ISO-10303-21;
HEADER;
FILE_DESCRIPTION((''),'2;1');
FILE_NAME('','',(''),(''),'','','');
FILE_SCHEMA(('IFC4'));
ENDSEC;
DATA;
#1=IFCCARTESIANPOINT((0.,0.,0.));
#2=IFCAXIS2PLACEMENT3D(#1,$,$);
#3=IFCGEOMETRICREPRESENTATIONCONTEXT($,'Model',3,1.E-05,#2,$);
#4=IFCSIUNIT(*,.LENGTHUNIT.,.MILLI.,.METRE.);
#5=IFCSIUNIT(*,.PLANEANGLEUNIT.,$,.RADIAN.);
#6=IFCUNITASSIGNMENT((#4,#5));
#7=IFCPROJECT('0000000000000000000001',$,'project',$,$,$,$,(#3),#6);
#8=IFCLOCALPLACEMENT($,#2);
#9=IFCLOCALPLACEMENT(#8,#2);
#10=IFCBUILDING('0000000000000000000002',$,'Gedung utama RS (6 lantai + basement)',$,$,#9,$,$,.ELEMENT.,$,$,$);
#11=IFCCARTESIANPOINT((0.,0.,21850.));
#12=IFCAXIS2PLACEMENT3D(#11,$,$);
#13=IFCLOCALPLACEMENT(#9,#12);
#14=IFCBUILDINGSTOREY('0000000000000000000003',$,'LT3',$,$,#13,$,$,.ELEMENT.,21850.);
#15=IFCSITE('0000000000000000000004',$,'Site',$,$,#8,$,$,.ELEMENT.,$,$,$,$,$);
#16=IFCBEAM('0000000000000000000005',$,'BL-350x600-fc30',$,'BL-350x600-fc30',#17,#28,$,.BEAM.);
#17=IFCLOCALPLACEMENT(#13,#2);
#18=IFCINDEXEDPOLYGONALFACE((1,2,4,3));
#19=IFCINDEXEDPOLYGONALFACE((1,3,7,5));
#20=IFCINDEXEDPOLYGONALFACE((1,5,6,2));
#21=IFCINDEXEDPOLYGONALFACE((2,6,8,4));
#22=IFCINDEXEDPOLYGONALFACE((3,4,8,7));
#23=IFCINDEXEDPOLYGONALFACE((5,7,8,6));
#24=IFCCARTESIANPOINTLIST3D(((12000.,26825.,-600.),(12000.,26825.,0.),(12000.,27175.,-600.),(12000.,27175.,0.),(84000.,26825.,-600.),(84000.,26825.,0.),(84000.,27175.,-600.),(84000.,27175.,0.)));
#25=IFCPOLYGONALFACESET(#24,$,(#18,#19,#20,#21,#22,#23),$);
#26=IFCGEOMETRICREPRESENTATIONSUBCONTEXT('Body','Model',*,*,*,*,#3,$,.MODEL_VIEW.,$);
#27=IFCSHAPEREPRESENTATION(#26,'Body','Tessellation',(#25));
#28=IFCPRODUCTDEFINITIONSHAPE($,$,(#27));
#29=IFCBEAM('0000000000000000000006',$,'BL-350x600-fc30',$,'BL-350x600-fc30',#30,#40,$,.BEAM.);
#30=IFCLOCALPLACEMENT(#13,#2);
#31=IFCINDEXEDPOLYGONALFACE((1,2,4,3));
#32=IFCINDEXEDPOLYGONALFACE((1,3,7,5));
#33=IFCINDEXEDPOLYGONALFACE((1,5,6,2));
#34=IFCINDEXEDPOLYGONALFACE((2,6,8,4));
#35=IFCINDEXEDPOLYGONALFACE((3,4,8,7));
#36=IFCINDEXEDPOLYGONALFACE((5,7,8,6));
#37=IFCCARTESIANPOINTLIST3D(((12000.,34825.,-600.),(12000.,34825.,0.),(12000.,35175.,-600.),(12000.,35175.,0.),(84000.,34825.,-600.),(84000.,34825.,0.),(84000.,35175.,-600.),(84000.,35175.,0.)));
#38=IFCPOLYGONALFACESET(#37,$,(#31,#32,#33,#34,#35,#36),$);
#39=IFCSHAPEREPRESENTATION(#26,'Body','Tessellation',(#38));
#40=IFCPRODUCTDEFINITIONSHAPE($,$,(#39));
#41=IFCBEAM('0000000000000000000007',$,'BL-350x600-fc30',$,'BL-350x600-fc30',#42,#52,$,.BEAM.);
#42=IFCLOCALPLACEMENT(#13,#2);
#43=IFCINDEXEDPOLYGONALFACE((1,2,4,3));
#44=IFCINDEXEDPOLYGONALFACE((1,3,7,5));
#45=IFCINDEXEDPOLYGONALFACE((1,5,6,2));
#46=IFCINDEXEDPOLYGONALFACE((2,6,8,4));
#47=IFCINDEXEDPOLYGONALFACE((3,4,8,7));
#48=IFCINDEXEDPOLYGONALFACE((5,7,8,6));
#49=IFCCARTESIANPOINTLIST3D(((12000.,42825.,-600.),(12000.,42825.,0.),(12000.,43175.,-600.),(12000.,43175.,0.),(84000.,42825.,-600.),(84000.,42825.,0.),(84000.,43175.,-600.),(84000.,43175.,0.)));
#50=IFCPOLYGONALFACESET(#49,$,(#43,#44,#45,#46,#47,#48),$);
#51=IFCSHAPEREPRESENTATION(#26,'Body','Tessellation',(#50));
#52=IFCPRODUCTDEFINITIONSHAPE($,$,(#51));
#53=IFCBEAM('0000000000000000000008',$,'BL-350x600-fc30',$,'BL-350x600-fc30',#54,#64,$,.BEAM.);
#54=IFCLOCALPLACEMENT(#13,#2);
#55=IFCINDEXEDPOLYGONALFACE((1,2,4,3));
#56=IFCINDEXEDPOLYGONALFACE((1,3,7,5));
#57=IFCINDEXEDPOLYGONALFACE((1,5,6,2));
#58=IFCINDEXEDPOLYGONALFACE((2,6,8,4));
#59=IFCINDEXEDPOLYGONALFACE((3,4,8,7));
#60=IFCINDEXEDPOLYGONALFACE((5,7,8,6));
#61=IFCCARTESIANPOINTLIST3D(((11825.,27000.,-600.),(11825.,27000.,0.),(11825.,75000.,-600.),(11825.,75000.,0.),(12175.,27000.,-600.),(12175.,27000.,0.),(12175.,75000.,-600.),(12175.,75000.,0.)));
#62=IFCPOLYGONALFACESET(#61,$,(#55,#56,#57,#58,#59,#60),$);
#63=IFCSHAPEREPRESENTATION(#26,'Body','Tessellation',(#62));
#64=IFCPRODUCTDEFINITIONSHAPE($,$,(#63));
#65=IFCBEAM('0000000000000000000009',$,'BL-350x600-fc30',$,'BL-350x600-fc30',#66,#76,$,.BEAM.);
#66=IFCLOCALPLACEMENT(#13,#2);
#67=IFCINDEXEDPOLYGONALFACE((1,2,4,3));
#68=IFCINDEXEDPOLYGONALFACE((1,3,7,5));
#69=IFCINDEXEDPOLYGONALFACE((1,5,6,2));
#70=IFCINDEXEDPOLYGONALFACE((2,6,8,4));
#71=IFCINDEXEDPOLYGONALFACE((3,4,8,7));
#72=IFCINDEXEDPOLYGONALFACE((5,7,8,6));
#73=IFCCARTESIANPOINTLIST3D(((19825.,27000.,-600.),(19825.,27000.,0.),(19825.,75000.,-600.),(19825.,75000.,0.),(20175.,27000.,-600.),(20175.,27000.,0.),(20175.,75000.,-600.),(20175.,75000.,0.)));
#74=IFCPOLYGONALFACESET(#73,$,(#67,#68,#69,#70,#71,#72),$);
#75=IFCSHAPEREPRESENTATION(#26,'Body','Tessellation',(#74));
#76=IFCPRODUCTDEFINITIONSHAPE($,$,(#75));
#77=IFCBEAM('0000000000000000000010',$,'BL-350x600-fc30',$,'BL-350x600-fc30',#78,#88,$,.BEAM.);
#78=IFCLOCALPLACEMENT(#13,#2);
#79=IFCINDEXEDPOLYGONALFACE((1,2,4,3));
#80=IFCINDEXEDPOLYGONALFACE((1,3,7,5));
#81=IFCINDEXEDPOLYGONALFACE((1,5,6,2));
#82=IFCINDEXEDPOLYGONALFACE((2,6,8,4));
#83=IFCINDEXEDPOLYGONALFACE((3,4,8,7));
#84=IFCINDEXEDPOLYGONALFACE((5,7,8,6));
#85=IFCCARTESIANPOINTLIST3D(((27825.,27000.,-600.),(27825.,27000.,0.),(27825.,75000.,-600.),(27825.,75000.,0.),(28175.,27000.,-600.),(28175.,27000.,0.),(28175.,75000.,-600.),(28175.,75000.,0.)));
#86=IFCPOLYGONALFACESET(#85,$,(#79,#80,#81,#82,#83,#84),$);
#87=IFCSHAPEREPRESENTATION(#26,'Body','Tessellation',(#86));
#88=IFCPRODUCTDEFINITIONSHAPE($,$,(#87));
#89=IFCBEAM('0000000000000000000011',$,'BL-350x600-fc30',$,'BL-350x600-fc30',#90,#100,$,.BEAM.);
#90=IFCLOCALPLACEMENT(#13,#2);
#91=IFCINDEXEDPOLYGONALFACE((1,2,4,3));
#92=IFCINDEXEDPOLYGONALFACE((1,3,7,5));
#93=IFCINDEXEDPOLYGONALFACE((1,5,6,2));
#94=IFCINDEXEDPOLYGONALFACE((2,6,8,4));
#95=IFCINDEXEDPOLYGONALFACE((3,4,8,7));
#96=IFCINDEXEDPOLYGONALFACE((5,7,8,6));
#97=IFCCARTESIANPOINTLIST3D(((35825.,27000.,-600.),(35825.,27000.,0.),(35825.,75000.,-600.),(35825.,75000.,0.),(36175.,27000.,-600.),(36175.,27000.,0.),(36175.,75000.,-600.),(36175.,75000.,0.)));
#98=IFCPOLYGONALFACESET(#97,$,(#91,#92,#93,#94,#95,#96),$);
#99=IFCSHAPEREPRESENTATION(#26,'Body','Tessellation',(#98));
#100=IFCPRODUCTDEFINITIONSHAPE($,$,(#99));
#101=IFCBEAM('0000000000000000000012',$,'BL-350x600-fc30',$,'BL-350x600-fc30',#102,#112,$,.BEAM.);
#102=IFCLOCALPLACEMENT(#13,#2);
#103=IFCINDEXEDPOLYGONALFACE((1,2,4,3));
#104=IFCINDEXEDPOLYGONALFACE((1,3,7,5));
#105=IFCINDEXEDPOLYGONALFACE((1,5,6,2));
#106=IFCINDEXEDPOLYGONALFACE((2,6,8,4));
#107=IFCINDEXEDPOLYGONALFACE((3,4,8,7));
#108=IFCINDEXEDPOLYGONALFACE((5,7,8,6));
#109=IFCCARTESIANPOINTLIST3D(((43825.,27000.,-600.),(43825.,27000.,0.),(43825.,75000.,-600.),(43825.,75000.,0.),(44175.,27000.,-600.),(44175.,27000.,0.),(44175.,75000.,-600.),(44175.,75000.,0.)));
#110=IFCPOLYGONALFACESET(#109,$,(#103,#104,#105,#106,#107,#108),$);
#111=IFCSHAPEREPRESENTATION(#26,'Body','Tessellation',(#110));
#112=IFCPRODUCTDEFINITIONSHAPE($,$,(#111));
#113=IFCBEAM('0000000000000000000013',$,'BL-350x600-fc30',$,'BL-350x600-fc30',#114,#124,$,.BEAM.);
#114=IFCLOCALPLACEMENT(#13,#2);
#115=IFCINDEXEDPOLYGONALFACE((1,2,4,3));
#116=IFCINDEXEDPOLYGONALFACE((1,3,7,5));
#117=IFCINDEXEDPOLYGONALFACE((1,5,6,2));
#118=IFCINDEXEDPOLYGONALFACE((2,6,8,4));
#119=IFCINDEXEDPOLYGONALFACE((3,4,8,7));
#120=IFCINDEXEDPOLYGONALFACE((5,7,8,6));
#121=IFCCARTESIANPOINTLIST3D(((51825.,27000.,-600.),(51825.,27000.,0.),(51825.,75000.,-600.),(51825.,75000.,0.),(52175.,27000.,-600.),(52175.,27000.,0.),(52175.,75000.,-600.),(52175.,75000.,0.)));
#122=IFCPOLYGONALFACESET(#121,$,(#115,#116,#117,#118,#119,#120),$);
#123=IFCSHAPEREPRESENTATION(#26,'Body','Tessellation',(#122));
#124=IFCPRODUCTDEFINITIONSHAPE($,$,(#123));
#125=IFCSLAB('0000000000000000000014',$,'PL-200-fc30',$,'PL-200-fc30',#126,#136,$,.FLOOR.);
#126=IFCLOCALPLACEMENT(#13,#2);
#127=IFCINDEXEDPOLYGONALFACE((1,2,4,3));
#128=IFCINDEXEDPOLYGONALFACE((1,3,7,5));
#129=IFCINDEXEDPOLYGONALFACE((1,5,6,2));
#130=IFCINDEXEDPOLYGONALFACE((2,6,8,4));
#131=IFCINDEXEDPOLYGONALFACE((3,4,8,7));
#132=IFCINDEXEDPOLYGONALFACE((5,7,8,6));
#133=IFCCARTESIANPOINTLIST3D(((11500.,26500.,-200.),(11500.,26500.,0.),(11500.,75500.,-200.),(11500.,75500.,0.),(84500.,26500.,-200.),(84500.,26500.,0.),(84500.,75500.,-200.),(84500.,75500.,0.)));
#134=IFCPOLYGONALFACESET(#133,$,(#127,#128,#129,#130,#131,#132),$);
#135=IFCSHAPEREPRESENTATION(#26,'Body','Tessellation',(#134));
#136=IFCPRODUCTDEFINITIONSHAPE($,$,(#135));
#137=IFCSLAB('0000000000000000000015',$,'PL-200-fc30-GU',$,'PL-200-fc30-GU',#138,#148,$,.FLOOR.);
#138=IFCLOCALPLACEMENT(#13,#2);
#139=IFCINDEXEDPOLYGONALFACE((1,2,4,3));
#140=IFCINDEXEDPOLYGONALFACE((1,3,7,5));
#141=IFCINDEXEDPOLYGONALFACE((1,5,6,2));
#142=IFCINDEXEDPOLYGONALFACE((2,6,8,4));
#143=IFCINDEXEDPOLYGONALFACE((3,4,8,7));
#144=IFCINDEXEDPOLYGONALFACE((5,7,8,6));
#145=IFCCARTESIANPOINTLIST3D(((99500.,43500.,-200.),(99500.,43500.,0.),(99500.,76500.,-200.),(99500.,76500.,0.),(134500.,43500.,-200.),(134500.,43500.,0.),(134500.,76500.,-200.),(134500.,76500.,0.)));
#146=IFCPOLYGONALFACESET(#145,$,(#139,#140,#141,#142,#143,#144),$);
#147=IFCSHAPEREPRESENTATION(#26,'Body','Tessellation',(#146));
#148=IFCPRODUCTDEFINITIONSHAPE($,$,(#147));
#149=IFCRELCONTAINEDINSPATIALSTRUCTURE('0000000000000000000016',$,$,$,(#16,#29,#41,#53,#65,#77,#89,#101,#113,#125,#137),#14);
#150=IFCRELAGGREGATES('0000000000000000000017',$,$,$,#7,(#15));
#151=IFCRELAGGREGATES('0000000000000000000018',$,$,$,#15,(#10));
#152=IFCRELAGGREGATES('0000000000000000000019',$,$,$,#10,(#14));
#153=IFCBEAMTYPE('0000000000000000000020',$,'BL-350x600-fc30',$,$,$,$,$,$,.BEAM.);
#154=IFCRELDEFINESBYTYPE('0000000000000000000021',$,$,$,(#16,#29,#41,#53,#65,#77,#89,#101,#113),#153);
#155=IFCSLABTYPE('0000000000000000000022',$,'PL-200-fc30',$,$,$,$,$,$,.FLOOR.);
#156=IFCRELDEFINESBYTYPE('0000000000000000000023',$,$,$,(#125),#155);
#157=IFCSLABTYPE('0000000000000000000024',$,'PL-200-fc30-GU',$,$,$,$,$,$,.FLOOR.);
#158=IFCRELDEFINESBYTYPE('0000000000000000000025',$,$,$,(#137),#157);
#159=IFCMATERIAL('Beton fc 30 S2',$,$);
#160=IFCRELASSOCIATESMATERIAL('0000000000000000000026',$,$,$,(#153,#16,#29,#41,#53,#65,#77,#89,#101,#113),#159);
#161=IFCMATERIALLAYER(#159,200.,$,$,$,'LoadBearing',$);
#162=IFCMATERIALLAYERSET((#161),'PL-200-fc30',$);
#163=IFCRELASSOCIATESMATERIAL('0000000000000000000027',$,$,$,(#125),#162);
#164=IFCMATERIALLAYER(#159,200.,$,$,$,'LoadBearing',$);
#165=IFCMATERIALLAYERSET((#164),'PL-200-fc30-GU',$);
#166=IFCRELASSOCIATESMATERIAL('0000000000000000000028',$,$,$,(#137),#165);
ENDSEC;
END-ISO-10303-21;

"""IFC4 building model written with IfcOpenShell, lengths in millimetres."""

from ifc_helpers import new_model, si_unit, frame, origin, origin_2d, place, context, subcontext, project, spatial, polyline, rectangle, outline, extrude, material, layer, layer_set, layer_usage, material_profile, profile_set, profile_usage, type_object, element, save


model = new_model("IFC4")

# Units and contexts
model_context = context("Model", 3, precision=1e-05, world=origin())
body_context = subcontext(model_context, "Body", "Model", "MODEL_VIEW")
ifc_project = project(units=[si_unit("LENGTHUNIT", "METRE", prefix="MILLI"), si_unit("PLANEANGLEUNIT", "RADIAN")], contexts=[model_context])

# Site, building, storey
site_placement = place(None, origin())
site = spatial("IfcSite", under=ifc_project, at=site_placement, Name="Site", CompositionType="ELEMENT")
building_placement = place(site_placement, origin())
building = spatial("IfcBuilding", under=site, at=building_placement, Name="Gedung utama RS (6 lantai + basement)", CompositionType="ELEMENT")
storey_placement = place(building_placement, frame((0.0, 0.0, 21850.0)))
storey = spatial("IfcBuildingStorey", under=building, at=storey_placement, Name="LT3", CompositionType="ELEMENT", Elevation=21850.0)

# Beams
ifc_material = material(Name="Beton fc 30 S2")
ifc_material_profile_1 = material_profile(ifc_material, rectangle(XDim=350.0, YDim=600.0, at=origin_2d()), Name="BL-350x600-fc30")
ifc_profile_set_1 = profile_set([ifc_material_profile_1], Name="BL-350x600-fc30")
ifc_profile_usage_1 = profile_usage(ifc_profile_set_1, cardinal=8)
beam_type = type_object("IfcBeamType", Name="BL-350x600-fc30", PredefinedType="BEAM", material=ifc_profile_set_1)
for number, where, name in (
    (1, (12000.0, 27000.0, -300.0), "BL-350x600-fc30"),
    (2, (12000.0, 35000.0, -300.0), "BL-350x600-fc30"),
    (3, (12000.0, 43000.0, -300.0), "BL-350x600-fc30"),
):
    element("IfcBeam", number, at=place(storey_placement, frame(where)), inside=storey, type_object=beam_type, material=ifc_profile_usage_1, Name=name, ObjectType="BL-350x600-fc30", PredefinedType="BEAM", context=body_context, shape_type="SweptSolid", body=[
        extrude(rectangle(XDim=350.0, YDim=600.0, at=origin_2d()), frame((0.0, 0.0, 0.0), z_axis=(1.0, 0.0, 0.0), x_axis=(0.0, 1.0, 0.0)), (0.0, 0.0, 1.0), 72000.0),
    ])
for number, where, name in (
    (4, (12000.0, 27000.0, -300.0), "BL-350x600-fc30"),
    (5, (20000.0, 27000.0, -300.0), "BL-350x600-fc30"),
    (6, (28000.0, 27000.0, -300.0), "BL-350x600-fc30"),
    (7, (36000.0, 27000.0, -300.0), "BL-350x600-fc30"),
    (8, (44000.0, 27000.0, -300.0), "BL-350x600-fc30"),
    (9, (52000.0, 27000.0, -300.0), "BL-350x600-fc30"),
):
    element("IfcBeam", number, at=place(storey_placement, frame(where)), inside=storey, type_object=beam_type, material=ifc_profile_usage_1, Name=name, ObjectType="BL-350x600-fc30", PredefinedType="BEAM", context=body_context, shape_type="SweptSolid", body=[
        extrude(rectangle(XDim=350.0, YDim=600.0, at=origin_2d()), frame((0.0, 0.0, 0.0), z_axis=(0.0, 1.0, 0.0), x_axis=(-1.0, 0.0, 0.0)), (0.0, 0.0, 1.0), 48000.0),
    ])

# Slabs
ifc_layer_1 = layer(ifc_material, 200.0, Category="LoadBearing")
ifc_layer_set_1 = layer_set([ifc_layer_1], Name="PL-200-fc30")
ifc_layer_usage_1 = layer_usage(ifc_layer_set_1, "AXIS3", "NEGATIVE", 0.0)
slab_type_1 = type_object("IfcSlabType", Name="PL-200-fc30", PredefinedType="FLOOR")
slab_1_placement = place(storey_placement, origin())
element("IfcSlab", 10, at=slab_1_placement, inside=storey, type_object=slab_type_1, material=ifc_layer_usage_1, Name="PL-200-fc30", ObjectType="PL-200-fc30", PredefinedType="FLOOR", context=body_context, shape_type="SweptSolid", body=[
    extrude(outline(polyline([(11500.0, 26500.0), (84500.0, 26500.0), (84500.0, 75500.0), (11500.0, 75500.0), (11500.0, 26500.0)])), frame((0.0, 0.0, -200.0)), (0.0, 0.0, 1.0), 200.0),
])
ifc_layer_2 = layer(ifc_material, 200.0, Category="LoadBearing")
ifc_layer_set_2 = layer_set([ifc_layer_2], Name="PL-200-fc30-GU")
ifc_layer_usage_2 = layer_usage(ifc_layer_set_2, "AXIS3", "NEGATIVE", 0.0)
slab_type_2 = type_object("IfcSlabType", Name="PL-200-fc30-GU", PredefinedType="FLOOR")
slab_2_placement = place(storey_placement, origin())
element("IfcSlab", 11, at=slab_2_placement, inside=storey, type_object=slab_type_2, material=ifc_layer_usage_2, Name="PL-200-fc30-GU", ObjectType="PL-200-fc30-GU", PredefinedType="FLOOR", context=body_context, shape_type="SweptSolid", body=[
    extrude(outline(polyline([(99500.0, 43500.0), (134500.0, 43500.0), (134500.0, 76500.0), (99500.0, 76500.0), (99500.0, 43500.0)])), frame((0.0, 0.0, -200.0)), (0.0, 0.0, 1.0), 200.0),
])

save(model, "model.ifc")
